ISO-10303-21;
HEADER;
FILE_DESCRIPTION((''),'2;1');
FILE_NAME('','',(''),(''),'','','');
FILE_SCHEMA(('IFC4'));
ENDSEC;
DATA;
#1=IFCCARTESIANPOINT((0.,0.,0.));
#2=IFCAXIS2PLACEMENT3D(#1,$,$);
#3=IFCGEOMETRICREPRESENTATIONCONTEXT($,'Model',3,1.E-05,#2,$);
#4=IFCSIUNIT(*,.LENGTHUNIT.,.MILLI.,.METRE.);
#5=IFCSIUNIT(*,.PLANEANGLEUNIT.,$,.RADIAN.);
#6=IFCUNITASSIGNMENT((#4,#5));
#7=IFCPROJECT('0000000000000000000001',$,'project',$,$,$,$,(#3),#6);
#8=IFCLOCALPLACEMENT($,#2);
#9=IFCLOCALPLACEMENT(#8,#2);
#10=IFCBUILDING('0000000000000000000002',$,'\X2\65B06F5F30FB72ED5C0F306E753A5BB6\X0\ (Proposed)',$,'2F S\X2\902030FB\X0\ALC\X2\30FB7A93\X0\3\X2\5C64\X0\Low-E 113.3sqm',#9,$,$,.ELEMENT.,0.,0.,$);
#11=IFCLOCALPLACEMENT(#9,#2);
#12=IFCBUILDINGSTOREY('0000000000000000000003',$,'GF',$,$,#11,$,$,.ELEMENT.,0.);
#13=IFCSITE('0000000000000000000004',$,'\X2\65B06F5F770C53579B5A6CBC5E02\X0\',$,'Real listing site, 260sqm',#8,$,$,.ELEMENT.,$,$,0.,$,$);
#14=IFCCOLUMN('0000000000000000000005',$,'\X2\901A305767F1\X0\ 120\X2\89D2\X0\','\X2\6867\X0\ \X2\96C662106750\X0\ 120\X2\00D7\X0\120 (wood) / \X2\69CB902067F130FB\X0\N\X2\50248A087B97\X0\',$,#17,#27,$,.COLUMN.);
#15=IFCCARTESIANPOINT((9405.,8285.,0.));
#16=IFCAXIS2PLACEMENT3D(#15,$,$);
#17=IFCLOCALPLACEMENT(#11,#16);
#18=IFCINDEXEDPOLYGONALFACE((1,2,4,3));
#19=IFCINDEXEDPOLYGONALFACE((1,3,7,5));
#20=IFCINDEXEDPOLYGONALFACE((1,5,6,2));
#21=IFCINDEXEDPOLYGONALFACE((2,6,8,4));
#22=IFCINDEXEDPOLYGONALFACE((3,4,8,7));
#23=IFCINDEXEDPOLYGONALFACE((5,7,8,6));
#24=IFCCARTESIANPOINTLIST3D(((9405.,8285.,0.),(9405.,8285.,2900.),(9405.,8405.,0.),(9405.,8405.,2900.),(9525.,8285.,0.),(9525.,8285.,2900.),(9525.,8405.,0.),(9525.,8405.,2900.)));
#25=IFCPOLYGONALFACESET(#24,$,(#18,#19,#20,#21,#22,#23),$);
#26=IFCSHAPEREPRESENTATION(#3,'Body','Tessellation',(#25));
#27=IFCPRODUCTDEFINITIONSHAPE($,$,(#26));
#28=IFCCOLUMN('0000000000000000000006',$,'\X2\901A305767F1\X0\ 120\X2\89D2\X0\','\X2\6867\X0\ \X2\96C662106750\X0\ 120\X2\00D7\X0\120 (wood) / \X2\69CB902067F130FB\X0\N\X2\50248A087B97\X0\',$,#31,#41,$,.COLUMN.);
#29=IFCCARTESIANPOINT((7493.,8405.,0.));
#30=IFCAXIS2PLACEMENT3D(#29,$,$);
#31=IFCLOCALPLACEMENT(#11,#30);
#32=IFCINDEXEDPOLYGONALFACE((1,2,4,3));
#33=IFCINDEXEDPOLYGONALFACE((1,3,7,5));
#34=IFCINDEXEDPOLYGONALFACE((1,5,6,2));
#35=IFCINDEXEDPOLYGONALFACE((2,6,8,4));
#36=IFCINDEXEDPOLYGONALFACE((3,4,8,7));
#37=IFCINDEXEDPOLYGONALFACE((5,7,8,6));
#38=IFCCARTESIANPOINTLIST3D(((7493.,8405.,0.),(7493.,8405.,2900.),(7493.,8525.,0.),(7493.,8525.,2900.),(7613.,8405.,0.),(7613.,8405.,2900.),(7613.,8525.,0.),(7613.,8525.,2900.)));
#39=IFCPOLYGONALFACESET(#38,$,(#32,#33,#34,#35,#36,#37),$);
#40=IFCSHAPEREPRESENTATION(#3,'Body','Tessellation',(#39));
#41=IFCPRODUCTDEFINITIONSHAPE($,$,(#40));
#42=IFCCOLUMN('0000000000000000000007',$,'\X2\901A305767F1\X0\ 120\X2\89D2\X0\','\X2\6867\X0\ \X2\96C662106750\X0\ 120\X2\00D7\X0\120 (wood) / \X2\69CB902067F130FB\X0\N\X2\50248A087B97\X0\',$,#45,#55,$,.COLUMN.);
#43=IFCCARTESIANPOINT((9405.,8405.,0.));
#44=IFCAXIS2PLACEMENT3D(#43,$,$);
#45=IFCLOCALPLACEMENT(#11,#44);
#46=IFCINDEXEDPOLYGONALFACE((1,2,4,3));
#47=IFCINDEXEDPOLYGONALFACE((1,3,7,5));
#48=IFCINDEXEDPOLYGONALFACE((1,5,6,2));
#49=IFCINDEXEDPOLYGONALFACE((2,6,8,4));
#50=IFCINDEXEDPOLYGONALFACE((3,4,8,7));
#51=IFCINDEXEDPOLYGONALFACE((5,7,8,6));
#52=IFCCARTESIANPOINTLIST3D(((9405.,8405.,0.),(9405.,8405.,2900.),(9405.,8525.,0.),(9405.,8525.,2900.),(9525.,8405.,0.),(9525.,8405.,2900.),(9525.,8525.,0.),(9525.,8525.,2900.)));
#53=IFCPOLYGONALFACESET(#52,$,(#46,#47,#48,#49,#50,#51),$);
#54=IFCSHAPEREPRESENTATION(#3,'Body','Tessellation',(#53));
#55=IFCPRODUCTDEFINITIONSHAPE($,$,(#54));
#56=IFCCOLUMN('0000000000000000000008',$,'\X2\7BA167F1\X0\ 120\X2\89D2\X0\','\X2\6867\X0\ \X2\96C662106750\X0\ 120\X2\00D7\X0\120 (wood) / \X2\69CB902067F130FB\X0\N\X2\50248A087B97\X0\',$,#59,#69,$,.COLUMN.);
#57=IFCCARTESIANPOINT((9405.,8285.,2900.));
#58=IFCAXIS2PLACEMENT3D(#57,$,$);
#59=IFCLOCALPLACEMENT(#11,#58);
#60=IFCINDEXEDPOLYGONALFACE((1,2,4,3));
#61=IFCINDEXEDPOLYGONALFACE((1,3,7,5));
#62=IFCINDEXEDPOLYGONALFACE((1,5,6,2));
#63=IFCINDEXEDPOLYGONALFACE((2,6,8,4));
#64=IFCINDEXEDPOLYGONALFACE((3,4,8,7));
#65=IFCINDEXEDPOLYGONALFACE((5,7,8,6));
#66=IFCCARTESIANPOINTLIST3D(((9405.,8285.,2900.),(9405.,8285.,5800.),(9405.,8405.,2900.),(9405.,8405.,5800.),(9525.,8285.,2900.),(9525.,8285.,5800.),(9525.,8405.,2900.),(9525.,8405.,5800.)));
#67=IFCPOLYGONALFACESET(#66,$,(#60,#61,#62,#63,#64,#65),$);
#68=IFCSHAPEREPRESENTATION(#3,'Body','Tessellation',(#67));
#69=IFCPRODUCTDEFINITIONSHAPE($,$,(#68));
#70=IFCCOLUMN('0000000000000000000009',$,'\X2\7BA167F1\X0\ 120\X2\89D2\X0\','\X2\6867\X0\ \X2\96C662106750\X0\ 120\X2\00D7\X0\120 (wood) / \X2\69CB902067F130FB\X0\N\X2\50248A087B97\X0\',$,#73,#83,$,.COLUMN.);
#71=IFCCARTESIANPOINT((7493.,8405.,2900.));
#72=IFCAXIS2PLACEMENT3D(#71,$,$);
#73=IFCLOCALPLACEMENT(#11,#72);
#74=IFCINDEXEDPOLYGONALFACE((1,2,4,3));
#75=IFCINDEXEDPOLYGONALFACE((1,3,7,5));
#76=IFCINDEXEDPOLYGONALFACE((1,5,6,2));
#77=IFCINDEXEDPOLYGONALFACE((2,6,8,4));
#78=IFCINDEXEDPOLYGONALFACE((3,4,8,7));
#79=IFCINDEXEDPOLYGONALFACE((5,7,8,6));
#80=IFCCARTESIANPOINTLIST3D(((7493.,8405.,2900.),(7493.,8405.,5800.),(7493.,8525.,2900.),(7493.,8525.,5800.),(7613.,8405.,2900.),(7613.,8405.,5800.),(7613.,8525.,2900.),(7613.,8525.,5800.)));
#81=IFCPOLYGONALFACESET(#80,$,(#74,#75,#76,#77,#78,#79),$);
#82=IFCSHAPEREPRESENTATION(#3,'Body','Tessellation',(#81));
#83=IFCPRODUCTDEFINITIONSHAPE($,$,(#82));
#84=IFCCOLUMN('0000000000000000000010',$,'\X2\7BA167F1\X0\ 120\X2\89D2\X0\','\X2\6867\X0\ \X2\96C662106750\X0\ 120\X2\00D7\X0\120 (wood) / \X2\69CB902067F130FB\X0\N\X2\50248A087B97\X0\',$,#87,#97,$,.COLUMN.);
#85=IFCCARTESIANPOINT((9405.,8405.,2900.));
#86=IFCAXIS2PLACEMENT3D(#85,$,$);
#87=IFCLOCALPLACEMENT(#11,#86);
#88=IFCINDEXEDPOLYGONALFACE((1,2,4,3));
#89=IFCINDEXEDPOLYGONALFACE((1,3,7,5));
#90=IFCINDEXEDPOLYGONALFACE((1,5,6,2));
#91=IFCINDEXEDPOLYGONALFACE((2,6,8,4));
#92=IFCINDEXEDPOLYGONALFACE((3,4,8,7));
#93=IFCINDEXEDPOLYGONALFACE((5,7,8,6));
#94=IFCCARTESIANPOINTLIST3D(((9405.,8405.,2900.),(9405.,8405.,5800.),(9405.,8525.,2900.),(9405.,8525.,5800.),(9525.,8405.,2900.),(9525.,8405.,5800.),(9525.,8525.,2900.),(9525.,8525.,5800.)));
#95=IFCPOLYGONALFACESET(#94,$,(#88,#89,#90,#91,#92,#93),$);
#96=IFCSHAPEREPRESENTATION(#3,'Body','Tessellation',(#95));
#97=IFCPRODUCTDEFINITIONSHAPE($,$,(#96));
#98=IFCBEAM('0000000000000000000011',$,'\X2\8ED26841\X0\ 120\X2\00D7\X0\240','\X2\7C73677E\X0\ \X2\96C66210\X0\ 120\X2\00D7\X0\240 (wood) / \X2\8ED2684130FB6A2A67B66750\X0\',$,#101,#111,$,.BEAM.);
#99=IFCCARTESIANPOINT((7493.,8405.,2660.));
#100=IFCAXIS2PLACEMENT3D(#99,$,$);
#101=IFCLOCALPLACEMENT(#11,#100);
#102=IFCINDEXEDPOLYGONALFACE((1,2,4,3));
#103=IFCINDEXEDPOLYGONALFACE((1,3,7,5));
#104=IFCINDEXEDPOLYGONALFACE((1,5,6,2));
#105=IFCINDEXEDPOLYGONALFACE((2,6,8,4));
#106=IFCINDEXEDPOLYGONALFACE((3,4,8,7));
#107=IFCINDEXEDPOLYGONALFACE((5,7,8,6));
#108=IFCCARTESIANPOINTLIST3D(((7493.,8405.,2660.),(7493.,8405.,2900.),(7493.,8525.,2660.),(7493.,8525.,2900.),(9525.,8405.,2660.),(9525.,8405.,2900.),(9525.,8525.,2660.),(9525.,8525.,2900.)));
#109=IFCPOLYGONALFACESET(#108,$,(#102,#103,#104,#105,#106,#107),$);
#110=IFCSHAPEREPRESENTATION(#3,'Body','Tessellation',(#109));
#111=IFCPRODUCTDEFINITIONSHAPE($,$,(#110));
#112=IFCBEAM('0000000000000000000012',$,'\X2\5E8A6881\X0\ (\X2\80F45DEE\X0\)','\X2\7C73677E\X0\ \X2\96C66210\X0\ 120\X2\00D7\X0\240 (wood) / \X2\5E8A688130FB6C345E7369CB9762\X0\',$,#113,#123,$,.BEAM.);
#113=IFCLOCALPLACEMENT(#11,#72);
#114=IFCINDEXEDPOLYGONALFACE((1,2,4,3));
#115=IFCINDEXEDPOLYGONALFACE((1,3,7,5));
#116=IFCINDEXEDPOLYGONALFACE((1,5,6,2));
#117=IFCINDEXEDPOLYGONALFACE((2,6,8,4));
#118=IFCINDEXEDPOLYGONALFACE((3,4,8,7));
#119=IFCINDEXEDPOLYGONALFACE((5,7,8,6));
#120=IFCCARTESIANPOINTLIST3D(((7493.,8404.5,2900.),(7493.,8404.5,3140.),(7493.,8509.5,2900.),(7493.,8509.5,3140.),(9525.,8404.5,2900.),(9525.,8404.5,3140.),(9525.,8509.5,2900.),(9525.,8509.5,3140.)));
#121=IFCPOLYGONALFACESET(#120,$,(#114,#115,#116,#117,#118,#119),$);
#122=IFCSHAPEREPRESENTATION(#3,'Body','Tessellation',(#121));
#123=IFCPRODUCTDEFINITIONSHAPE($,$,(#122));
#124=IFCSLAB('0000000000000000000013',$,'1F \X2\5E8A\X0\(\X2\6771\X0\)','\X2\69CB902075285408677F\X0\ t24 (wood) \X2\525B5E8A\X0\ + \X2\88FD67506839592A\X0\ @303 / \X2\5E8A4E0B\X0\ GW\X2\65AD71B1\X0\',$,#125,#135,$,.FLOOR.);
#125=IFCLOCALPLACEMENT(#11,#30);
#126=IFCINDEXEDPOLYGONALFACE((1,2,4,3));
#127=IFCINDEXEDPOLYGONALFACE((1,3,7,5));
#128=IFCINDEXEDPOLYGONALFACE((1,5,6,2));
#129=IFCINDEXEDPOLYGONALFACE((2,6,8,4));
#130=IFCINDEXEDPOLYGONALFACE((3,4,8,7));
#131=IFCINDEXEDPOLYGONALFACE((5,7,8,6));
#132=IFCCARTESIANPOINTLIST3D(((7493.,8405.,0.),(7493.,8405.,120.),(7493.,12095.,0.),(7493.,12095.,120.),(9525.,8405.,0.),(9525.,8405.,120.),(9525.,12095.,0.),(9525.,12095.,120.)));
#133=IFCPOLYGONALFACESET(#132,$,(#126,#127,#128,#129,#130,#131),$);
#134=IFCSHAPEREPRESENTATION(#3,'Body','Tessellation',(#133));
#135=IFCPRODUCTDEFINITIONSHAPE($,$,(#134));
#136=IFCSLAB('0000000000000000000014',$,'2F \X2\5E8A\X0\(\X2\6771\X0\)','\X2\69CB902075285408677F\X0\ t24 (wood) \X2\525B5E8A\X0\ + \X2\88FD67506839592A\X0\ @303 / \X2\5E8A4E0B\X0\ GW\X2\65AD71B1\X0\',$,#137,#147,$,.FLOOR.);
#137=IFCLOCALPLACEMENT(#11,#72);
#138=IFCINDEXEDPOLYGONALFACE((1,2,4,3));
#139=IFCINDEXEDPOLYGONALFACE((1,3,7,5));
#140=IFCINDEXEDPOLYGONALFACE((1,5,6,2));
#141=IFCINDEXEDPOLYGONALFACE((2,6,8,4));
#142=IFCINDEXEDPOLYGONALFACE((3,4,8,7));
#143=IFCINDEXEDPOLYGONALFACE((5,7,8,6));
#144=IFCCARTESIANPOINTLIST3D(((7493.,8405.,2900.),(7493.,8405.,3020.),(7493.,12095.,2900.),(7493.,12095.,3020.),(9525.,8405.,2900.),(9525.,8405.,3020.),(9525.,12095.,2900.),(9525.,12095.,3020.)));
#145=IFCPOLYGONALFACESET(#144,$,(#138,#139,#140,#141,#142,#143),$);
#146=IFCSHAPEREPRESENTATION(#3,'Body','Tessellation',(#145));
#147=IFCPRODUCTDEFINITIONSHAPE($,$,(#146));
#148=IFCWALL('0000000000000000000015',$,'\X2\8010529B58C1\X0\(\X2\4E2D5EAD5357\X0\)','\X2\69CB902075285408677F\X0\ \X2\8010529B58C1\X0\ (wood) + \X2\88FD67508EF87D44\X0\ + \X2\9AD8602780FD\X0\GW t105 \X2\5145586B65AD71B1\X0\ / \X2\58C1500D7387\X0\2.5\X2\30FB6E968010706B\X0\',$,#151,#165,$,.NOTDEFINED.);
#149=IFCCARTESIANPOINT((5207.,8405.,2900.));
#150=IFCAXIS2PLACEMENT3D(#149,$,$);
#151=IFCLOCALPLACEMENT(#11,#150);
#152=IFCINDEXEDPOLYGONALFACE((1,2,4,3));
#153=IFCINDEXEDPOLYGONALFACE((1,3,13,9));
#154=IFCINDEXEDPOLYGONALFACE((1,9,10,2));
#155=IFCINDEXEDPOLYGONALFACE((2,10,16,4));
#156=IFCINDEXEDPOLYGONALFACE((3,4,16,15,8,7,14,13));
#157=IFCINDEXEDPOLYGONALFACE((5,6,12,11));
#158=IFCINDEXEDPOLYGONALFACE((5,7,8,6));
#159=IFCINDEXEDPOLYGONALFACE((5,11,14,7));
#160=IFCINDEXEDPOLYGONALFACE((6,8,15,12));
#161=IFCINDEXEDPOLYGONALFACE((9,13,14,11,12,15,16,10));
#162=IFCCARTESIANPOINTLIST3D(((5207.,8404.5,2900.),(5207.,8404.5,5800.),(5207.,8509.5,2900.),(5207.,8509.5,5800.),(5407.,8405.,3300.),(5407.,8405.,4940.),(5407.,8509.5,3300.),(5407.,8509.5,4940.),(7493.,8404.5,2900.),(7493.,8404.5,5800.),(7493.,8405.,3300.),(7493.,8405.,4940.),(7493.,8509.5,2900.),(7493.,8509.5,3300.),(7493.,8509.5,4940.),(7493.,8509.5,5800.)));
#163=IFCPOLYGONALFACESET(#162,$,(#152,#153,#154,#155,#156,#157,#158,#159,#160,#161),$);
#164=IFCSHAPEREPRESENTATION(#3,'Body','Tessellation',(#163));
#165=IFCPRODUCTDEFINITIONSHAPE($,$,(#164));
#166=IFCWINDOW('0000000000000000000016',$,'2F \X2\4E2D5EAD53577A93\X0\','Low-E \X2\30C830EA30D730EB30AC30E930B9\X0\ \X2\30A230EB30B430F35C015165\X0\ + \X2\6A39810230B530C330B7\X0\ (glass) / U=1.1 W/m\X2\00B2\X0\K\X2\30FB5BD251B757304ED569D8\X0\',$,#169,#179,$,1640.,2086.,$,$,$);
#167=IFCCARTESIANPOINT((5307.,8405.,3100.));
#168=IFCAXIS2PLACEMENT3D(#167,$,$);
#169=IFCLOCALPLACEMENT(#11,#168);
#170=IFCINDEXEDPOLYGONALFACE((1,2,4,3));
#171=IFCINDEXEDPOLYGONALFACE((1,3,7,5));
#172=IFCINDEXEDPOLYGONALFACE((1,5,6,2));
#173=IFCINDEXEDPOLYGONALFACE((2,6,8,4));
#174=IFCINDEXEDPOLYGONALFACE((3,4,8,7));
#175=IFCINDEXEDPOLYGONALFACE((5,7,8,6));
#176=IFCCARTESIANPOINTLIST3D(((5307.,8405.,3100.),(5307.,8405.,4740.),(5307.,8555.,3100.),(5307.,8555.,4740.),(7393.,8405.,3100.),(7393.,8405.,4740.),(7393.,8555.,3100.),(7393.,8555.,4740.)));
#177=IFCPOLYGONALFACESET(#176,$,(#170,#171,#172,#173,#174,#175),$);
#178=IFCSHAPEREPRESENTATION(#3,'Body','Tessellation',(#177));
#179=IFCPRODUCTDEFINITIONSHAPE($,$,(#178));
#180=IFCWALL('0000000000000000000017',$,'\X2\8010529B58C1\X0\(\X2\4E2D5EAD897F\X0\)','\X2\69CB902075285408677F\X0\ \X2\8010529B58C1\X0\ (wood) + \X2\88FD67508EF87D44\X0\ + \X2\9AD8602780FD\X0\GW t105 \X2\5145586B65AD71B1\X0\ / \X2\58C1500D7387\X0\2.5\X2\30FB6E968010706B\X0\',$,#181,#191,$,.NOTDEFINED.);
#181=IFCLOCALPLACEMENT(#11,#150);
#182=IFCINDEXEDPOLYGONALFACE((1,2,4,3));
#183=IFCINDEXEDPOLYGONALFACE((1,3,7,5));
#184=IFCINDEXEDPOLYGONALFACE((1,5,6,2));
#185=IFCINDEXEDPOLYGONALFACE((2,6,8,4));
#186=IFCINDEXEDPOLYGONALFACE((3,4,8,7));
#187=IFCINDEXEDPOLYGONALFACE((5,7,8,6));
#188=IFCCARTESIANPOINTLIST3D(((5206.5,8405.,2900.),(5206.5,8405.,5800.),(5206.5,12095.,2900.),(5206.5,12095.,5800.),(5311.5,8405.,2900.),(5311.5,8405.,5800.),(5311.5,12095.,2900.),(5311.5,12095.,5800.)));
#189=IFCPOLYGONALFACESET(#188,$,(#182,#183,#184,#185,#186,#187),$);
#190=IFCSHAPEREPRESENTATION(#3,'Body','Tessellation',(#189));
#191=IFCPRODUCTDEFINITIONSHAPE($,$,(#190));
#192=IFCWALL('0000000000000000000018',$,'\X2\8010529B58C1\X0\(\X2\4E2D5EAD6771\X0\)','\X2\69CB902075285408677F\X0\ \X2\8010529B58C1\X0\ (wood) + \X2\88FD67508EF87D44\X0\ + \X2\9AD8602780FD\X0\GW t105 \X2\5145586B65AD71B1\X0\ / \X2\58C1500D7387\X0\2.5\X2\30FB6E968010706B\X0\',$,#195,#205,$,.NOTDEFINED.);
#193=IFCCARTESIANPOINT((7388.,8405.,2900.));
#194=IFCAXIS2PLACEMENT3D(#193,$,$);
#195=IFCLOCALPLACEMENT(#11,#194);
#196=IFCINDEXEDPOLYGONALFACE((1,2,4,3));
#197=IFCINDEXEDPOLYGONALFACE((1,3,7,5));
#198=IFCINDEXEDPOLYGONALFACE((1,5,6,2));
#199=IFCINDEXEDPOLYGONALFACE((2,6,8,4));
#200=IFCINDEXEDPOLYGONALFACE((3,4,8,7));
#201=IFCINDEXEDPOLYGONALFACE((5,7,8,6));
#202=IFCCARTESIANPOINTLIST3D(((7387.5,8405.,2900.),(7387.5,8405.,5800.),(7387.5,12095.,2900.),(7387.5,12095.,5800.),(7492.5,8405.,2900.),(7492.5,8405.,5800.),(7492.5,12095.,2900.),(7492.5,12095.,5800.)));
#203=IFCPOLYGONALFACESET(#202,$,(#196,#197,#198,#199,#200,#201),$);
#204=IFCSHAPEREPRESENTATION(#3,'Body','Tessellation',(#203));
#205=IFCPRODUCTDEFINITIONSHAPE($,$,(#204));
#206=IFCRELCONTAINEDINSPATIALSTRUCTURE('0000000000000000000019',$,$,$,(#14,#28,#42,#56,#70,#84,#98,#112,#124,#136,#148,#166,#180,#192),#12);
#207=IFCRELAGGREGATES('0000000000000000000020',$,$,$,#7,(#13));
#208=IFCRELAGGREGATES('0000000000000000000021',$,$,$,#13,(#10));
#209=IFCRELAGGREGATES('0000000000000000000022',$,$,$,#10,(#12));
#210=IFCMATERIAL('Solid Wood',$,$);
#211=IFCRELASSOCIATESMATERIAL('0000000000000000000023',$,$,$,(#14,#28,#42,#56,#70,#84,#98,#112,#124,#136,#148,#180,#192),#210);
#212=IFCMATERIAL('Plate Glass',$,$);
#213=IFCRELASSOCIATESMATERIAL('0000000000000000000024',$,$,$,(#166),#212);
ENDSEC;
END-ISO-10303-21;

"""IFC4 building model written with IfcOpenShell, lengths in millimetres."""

from ifc_helpers import new_model, si_unit, frame, frame_2d, origin, place, context, project, spatial, rectangle, extrude, material, element, fill, save


model = new_model("IFC4")

# Units and contexts
model_context = context("Model", 3, precision=1e-05, world=origin())
ifc_project = project(units=[si_unit("LENGTHUNIT", "METRE", prefix="MILLI"), si_unit("PLANEANGLEUNIT", "RADIAN")], contexts=[model_context])

# Site, building, storey
site_placement = place(None, origin())
site = spatial("IfcSite", under=ifc_project, at=site_placement, Name="新潟県南魚沼市", ObjectType="Real listing site, 260sqm", CompositionType="ELEMENT", RefElevation=0.0)
building_placement = place(site_placement, origin())
building = spatial("IfcBuilding", under=site, at=building_placement, Name="新潟・狭小の町家 (Proposed)", ObjectType="2F S造・ALC・窓3層Low-E 113.3sqm", CompositionType="ELEMENT", ElevationOfRefHeight=0.0, ElevationOfTerrain=0.0)
storey_placement = place(building_placement, origin())
storey = spatial("IfcBuildingStorey", under=building, at=storey_placement, Name="GF", CompositionType="ELEMENT", Elevation=0.0)

# Columns
ifc_material_1 = material(Name="Solid Wood")
column_1_placement = place(storey_placement, frame((9405.0, 8285.0, 0.0)))
element("IfcColumn", 1, at=column_1_placement, inside=storey, material=ifc_material_1, Name="通し柱 120角", Description="桧 集成材 120×120 (wood) / 構造柱・N値計算", PredefinedType="COLUMN", context=model_context, shape_type="SweptSolid", body=[
    extrude(rectangle(XDim=120.0, YDim=120.0, at=frame_2d((60.0, 60.0))), frame((9405.0, 8285.0, 0.0)), (0.0, 0.0, 1.0), 2900.0),
])
column_2_placement = place(storey_placement, frame((7493.0, 8405.0, 0.0)))
element("IfcColumn", 2, at=column_2_placement, inside=storey, material=ifc_material_1, Name="通し柱 120角", Description="桧 集成材 120×120 (wood) / 構造柱・N値計算", PredefinedType="COLUMN", context=model_context, shape_type="SweptSolid", body=[
    extrude(rectangle(XDim=120.0, YDim=120.0, at=frame_2d((60.0, 60.0))), frame((7493.0, 8405.0, 0.0)), (0.0, 0.0, 1.0), 2900.0),
])
column_3_placement = place(storey_placement, frame((9405.0, 8405.0, 0.0)))
element("IfcColumn", 3, at=column_3_placement, inside=storey, material=ifc_material_1, Name="通し柱 120角", Description="桧 集成材 120×120 (wood) / 構造柱・N値計算", PredefinedType="COLUMN", context=model_context, shape_type="SweptSolid", body=[
    extrude(rectangle(XDim=120.0, YDim=120.0, at=frame_2d((60.0, 60.0))), frame((9405.0, 8405.0, 0.0)), (0.0, 0.0, 1.0), 2900.0),
])
column_4_placement = place(storey_placement, frame((9405.0, 8285.0, 2900.0)))
element("IfcColumn", 4, at=column_4_placement, inside=storey, material=ifc_material_1, Name="管柱 120角", Description="桧 集成材 120×120 (wood) / 構造柱・N値計算", PredefinedType="COLUMN", context=model_context, shape_type="SweptSolid", body=[
    extrude(rectangle(XDim=120.0, YDim=120.0, at=frame_2d((60.0, 60.0))), frame((9405.0, 8285.0, 2900.0)), (0.0, 0.0, 1.0), 2900.0),
])
column_5_placement = place(storey_placement, frame((7493.0, 8405.0, 2900.0)))
element("IfcColumn", 5, at=column_5_placement, inside=storey, material=ifc_material_1, Name="管柱 120角", Description="桧 集成材 120×120 (wood) / 構造柱・N値計算", PredefinedType="COLUMN", context=model_context, shape_type="SweptSolid", body=[
    extrude(rectangle(XDim=120.0, YDim=120.0, at=frame_2d((60.0, 60.0))), frame((7493.0, 8405.0, 2900.0)), (0.0, 0.0, 1.0), 2900.0),
])
column_6_placement = place(storey_placement, frame((9405.0, 8405.0, 2900.0)))
element("IfcColumn", 6, at=column_6_placement, inside=storey, material=ifc_material_1, Name="管柱 120角", Description="桧 集成材 120×120 (wood) / 構造柱・N値計算", PredefinedType="COLUMN", context=model_context, shape_type="SweptSolid", body=[
    extrude(rectangle(XDim=120.0, YDim=120.0, at=frame_2d((60.0, 60.0))), frame((9405.0, 8405.0, 2900.0)), (0.0, 0.0, 1.0), 2900.0),
])

# Beams
beam_1_placement = place(storey_placement, frame((7493.0, 8405.0, 2660.0)))
element("IfcBeam", 7, at=beam_1_placement, inside=storey, material=ifc_material_1, Name="軒桁 120×240", Description="米松 集成 120×240 (wood) / 軒桁・横架材", PredefinedType="BEAM", context=model_context, shape_type="SweptSolid", body=[
    extrude(rectangle(XDim=2032.0, YDim=120.0, at=frame_2d((1016.0, 60.0))), frame((7493.0, 8405.0, 2660.0)), (0.0, 0.0, 1.0), 240.0),
])
beam_2_placement = place(storey_placement, frame((7493.0, 8405.0, 2900.0)))
element("IfcBeam", 8, at=beam_2_placement, inside=storey, material=ifc_material_1, Name="床梁 (胴差)", Description="米松 集成 120×240 (wood) / 床梁・水平構面", PredefinedType="BEAM", context=model_context, shape_type="SweptSolid", body=[
    extrude(rectangle(XDim=2032.0, YDim=105.0, at=frame_2d((1016.0, 52.0))), frame((7493.0, 8405.0, 2900.0)), (0.0, 0.0, 1.0), 240.0),
])

# Slabs
slab_1_placement = place(storey_placement, frame((7493.0, 8405.0, 0.0)))
element("IfcSlab", 9, at=slab_1_placement, inside=storey, material=ifc_material_1, Name="1F 床(東)", Description="構造用合板 t24 (wood) 剛床 + 製材根太 @303 / 床下 GW断熱", PredefinedType="FLOOR", context=model_context, shape_type="SweptSolid", body=[
    extrude(rectangle(XDim=2032.0, YDim=3690.0, at=frame_2d((1016.0, 1845.0))), frame((7493.0, 8405.0, 0.0)), (0.0, 0.0, 1.0), 120.0),
])
slab_2_placement = place(storey_placement, frame((7493.0, 8405.0, 2900.0)))
element("IfcSlab", 10, at=slab_2_placement, inside=storey, material=ifc_material_1, Name="2F 床(東)", Description="構造用合板 t24 (wood) 剛床 + 製材根太 @303 / 床下 GW断熱", PredefinedType="FLOOR", context=model_context, shape_type="SweptSolid", body=[
    extrude(rectangle(XDim=2032.0, YDim=3690.0, at=frame_2d((1016.0, 1845.0))), frame((7493.0, 8405.0, 2900.0)), (0.0, 0.0, 1.0), 120.0),
])

# Wall, opening, window
wall_1_placement = place(storey_placement, frame((5207.0, 8405.0, 2900.0)))
wall_1 = element("IfcWall", 11, at=wall_1_placement, inside=storey, material=ifc_material_1, Name="耐力壁(中庭南)", Description="構造用合板 耐力壁 (wood) + 製材軸組 + 高性能GW t105 充填断熱 / 壁倍率2.5・準耐火", PredefinedType="NOTDEFINED", context=model_context, shape_type="SweptSolid", body=[
    extrude(rectangle(XDim=2286.0, YDim=105.0, at=frame_2d((1143.0, 52.0))), frame((5207.0, 8405.0, 2900.0)), (0.0, 0.0, 1.0), 2900.0),
])
opening_placement = place(storey_placement, frame((5307.0, 8405.0, 3100.0)))
opening = element("IfcOpeningElement", 12, at=opening_placement, cuts=wall_1, PredefinedType="NOTDEFINED", context=model_context, shape_type="SweptSolid", body=[
    extrude(rectangle(XDim=2086.0, YDim=150.0, at=frame_2d((1043.0, 75.0))), frame((5307.0, 8405.0, 3100.0)), (0.0, 0.0, 1.0), 1640.0),
])
ifc_material_2 = material(Name="Plate Glass")
window_placement = place(storey_placement, frame((5307.0, 8405.0, 3100.0)))
window = element("IfcWindow", 13, at=window_placement, inside=storey, material=ifc_material_2, Name="2F 中庭南窓", Description="Low-E トリプルガラス アルゴン封入 + 樹脂サッシ (glass) / U=1.1 W/m²K・寒冷地仕様", OverallHeight=1640.0, OverallWidth=2086.0, context=model_context, shape_type="SweptSolid", body=[
    extrude(rectangle(XDim=2086.0, YDim=150.0, at=frame_2d((1043.0, 75.0))), frame((5307.0, 8405.0, 3100.0)), (0.0, 0.0, 1.0), 1640.0),
])
fill(opening, window)

# Walls
wall_2_placement = place(storey_placement, frame((5207.0, 8405.0, 2900.0)))
element("IfcWall", 14, at=wall_2_placement, inside=storey, material=ifc_material_1, Name="耐力壁(中庭西)", Description="構造用合板 耐力壁 (wood) + 製材軸組 + 高性能GW t105 充填断熱 / 壁倍率2.5・準耐火", PredefinedType="NOTDEFINED", context=model_context, shape_type="SweptSolid", body=[
    extrude(rectangle(XDim=105.0, YDim=3690.0, at=frame_2d((52.0, 1845.0))), frame((5207.0, 8405.0, 2900.0)), (0.0, 0.0, 1.0), 2900.0),
])
wall_3_placement = place(storey_placement, frame((7388.0, 8405.0, 2900.0)))
element("IfcWall", 15, at=wall_3_placement, inside=storey, material=ifc_material_1, Name="耐力壁(中庭東)", Description="構造用合板 耐力壁 (wood) + 製材軸組 + 高性能GW t105 充填断熱 / 壁倍率2.5・準耐火", PredefinedType="NOTDEFINED", context=model_context, shape_type="SweptSolid", body=[
    extrude(rectangle(XDim=105.0, YDim=3690.0, at=frame_2d((52.0, 1845.0))), frame((7388.0, 8405.0, 2900.0)), (0.0, 0.0, 1.0), 2900.0),
])

save(model, "model.ifc")
